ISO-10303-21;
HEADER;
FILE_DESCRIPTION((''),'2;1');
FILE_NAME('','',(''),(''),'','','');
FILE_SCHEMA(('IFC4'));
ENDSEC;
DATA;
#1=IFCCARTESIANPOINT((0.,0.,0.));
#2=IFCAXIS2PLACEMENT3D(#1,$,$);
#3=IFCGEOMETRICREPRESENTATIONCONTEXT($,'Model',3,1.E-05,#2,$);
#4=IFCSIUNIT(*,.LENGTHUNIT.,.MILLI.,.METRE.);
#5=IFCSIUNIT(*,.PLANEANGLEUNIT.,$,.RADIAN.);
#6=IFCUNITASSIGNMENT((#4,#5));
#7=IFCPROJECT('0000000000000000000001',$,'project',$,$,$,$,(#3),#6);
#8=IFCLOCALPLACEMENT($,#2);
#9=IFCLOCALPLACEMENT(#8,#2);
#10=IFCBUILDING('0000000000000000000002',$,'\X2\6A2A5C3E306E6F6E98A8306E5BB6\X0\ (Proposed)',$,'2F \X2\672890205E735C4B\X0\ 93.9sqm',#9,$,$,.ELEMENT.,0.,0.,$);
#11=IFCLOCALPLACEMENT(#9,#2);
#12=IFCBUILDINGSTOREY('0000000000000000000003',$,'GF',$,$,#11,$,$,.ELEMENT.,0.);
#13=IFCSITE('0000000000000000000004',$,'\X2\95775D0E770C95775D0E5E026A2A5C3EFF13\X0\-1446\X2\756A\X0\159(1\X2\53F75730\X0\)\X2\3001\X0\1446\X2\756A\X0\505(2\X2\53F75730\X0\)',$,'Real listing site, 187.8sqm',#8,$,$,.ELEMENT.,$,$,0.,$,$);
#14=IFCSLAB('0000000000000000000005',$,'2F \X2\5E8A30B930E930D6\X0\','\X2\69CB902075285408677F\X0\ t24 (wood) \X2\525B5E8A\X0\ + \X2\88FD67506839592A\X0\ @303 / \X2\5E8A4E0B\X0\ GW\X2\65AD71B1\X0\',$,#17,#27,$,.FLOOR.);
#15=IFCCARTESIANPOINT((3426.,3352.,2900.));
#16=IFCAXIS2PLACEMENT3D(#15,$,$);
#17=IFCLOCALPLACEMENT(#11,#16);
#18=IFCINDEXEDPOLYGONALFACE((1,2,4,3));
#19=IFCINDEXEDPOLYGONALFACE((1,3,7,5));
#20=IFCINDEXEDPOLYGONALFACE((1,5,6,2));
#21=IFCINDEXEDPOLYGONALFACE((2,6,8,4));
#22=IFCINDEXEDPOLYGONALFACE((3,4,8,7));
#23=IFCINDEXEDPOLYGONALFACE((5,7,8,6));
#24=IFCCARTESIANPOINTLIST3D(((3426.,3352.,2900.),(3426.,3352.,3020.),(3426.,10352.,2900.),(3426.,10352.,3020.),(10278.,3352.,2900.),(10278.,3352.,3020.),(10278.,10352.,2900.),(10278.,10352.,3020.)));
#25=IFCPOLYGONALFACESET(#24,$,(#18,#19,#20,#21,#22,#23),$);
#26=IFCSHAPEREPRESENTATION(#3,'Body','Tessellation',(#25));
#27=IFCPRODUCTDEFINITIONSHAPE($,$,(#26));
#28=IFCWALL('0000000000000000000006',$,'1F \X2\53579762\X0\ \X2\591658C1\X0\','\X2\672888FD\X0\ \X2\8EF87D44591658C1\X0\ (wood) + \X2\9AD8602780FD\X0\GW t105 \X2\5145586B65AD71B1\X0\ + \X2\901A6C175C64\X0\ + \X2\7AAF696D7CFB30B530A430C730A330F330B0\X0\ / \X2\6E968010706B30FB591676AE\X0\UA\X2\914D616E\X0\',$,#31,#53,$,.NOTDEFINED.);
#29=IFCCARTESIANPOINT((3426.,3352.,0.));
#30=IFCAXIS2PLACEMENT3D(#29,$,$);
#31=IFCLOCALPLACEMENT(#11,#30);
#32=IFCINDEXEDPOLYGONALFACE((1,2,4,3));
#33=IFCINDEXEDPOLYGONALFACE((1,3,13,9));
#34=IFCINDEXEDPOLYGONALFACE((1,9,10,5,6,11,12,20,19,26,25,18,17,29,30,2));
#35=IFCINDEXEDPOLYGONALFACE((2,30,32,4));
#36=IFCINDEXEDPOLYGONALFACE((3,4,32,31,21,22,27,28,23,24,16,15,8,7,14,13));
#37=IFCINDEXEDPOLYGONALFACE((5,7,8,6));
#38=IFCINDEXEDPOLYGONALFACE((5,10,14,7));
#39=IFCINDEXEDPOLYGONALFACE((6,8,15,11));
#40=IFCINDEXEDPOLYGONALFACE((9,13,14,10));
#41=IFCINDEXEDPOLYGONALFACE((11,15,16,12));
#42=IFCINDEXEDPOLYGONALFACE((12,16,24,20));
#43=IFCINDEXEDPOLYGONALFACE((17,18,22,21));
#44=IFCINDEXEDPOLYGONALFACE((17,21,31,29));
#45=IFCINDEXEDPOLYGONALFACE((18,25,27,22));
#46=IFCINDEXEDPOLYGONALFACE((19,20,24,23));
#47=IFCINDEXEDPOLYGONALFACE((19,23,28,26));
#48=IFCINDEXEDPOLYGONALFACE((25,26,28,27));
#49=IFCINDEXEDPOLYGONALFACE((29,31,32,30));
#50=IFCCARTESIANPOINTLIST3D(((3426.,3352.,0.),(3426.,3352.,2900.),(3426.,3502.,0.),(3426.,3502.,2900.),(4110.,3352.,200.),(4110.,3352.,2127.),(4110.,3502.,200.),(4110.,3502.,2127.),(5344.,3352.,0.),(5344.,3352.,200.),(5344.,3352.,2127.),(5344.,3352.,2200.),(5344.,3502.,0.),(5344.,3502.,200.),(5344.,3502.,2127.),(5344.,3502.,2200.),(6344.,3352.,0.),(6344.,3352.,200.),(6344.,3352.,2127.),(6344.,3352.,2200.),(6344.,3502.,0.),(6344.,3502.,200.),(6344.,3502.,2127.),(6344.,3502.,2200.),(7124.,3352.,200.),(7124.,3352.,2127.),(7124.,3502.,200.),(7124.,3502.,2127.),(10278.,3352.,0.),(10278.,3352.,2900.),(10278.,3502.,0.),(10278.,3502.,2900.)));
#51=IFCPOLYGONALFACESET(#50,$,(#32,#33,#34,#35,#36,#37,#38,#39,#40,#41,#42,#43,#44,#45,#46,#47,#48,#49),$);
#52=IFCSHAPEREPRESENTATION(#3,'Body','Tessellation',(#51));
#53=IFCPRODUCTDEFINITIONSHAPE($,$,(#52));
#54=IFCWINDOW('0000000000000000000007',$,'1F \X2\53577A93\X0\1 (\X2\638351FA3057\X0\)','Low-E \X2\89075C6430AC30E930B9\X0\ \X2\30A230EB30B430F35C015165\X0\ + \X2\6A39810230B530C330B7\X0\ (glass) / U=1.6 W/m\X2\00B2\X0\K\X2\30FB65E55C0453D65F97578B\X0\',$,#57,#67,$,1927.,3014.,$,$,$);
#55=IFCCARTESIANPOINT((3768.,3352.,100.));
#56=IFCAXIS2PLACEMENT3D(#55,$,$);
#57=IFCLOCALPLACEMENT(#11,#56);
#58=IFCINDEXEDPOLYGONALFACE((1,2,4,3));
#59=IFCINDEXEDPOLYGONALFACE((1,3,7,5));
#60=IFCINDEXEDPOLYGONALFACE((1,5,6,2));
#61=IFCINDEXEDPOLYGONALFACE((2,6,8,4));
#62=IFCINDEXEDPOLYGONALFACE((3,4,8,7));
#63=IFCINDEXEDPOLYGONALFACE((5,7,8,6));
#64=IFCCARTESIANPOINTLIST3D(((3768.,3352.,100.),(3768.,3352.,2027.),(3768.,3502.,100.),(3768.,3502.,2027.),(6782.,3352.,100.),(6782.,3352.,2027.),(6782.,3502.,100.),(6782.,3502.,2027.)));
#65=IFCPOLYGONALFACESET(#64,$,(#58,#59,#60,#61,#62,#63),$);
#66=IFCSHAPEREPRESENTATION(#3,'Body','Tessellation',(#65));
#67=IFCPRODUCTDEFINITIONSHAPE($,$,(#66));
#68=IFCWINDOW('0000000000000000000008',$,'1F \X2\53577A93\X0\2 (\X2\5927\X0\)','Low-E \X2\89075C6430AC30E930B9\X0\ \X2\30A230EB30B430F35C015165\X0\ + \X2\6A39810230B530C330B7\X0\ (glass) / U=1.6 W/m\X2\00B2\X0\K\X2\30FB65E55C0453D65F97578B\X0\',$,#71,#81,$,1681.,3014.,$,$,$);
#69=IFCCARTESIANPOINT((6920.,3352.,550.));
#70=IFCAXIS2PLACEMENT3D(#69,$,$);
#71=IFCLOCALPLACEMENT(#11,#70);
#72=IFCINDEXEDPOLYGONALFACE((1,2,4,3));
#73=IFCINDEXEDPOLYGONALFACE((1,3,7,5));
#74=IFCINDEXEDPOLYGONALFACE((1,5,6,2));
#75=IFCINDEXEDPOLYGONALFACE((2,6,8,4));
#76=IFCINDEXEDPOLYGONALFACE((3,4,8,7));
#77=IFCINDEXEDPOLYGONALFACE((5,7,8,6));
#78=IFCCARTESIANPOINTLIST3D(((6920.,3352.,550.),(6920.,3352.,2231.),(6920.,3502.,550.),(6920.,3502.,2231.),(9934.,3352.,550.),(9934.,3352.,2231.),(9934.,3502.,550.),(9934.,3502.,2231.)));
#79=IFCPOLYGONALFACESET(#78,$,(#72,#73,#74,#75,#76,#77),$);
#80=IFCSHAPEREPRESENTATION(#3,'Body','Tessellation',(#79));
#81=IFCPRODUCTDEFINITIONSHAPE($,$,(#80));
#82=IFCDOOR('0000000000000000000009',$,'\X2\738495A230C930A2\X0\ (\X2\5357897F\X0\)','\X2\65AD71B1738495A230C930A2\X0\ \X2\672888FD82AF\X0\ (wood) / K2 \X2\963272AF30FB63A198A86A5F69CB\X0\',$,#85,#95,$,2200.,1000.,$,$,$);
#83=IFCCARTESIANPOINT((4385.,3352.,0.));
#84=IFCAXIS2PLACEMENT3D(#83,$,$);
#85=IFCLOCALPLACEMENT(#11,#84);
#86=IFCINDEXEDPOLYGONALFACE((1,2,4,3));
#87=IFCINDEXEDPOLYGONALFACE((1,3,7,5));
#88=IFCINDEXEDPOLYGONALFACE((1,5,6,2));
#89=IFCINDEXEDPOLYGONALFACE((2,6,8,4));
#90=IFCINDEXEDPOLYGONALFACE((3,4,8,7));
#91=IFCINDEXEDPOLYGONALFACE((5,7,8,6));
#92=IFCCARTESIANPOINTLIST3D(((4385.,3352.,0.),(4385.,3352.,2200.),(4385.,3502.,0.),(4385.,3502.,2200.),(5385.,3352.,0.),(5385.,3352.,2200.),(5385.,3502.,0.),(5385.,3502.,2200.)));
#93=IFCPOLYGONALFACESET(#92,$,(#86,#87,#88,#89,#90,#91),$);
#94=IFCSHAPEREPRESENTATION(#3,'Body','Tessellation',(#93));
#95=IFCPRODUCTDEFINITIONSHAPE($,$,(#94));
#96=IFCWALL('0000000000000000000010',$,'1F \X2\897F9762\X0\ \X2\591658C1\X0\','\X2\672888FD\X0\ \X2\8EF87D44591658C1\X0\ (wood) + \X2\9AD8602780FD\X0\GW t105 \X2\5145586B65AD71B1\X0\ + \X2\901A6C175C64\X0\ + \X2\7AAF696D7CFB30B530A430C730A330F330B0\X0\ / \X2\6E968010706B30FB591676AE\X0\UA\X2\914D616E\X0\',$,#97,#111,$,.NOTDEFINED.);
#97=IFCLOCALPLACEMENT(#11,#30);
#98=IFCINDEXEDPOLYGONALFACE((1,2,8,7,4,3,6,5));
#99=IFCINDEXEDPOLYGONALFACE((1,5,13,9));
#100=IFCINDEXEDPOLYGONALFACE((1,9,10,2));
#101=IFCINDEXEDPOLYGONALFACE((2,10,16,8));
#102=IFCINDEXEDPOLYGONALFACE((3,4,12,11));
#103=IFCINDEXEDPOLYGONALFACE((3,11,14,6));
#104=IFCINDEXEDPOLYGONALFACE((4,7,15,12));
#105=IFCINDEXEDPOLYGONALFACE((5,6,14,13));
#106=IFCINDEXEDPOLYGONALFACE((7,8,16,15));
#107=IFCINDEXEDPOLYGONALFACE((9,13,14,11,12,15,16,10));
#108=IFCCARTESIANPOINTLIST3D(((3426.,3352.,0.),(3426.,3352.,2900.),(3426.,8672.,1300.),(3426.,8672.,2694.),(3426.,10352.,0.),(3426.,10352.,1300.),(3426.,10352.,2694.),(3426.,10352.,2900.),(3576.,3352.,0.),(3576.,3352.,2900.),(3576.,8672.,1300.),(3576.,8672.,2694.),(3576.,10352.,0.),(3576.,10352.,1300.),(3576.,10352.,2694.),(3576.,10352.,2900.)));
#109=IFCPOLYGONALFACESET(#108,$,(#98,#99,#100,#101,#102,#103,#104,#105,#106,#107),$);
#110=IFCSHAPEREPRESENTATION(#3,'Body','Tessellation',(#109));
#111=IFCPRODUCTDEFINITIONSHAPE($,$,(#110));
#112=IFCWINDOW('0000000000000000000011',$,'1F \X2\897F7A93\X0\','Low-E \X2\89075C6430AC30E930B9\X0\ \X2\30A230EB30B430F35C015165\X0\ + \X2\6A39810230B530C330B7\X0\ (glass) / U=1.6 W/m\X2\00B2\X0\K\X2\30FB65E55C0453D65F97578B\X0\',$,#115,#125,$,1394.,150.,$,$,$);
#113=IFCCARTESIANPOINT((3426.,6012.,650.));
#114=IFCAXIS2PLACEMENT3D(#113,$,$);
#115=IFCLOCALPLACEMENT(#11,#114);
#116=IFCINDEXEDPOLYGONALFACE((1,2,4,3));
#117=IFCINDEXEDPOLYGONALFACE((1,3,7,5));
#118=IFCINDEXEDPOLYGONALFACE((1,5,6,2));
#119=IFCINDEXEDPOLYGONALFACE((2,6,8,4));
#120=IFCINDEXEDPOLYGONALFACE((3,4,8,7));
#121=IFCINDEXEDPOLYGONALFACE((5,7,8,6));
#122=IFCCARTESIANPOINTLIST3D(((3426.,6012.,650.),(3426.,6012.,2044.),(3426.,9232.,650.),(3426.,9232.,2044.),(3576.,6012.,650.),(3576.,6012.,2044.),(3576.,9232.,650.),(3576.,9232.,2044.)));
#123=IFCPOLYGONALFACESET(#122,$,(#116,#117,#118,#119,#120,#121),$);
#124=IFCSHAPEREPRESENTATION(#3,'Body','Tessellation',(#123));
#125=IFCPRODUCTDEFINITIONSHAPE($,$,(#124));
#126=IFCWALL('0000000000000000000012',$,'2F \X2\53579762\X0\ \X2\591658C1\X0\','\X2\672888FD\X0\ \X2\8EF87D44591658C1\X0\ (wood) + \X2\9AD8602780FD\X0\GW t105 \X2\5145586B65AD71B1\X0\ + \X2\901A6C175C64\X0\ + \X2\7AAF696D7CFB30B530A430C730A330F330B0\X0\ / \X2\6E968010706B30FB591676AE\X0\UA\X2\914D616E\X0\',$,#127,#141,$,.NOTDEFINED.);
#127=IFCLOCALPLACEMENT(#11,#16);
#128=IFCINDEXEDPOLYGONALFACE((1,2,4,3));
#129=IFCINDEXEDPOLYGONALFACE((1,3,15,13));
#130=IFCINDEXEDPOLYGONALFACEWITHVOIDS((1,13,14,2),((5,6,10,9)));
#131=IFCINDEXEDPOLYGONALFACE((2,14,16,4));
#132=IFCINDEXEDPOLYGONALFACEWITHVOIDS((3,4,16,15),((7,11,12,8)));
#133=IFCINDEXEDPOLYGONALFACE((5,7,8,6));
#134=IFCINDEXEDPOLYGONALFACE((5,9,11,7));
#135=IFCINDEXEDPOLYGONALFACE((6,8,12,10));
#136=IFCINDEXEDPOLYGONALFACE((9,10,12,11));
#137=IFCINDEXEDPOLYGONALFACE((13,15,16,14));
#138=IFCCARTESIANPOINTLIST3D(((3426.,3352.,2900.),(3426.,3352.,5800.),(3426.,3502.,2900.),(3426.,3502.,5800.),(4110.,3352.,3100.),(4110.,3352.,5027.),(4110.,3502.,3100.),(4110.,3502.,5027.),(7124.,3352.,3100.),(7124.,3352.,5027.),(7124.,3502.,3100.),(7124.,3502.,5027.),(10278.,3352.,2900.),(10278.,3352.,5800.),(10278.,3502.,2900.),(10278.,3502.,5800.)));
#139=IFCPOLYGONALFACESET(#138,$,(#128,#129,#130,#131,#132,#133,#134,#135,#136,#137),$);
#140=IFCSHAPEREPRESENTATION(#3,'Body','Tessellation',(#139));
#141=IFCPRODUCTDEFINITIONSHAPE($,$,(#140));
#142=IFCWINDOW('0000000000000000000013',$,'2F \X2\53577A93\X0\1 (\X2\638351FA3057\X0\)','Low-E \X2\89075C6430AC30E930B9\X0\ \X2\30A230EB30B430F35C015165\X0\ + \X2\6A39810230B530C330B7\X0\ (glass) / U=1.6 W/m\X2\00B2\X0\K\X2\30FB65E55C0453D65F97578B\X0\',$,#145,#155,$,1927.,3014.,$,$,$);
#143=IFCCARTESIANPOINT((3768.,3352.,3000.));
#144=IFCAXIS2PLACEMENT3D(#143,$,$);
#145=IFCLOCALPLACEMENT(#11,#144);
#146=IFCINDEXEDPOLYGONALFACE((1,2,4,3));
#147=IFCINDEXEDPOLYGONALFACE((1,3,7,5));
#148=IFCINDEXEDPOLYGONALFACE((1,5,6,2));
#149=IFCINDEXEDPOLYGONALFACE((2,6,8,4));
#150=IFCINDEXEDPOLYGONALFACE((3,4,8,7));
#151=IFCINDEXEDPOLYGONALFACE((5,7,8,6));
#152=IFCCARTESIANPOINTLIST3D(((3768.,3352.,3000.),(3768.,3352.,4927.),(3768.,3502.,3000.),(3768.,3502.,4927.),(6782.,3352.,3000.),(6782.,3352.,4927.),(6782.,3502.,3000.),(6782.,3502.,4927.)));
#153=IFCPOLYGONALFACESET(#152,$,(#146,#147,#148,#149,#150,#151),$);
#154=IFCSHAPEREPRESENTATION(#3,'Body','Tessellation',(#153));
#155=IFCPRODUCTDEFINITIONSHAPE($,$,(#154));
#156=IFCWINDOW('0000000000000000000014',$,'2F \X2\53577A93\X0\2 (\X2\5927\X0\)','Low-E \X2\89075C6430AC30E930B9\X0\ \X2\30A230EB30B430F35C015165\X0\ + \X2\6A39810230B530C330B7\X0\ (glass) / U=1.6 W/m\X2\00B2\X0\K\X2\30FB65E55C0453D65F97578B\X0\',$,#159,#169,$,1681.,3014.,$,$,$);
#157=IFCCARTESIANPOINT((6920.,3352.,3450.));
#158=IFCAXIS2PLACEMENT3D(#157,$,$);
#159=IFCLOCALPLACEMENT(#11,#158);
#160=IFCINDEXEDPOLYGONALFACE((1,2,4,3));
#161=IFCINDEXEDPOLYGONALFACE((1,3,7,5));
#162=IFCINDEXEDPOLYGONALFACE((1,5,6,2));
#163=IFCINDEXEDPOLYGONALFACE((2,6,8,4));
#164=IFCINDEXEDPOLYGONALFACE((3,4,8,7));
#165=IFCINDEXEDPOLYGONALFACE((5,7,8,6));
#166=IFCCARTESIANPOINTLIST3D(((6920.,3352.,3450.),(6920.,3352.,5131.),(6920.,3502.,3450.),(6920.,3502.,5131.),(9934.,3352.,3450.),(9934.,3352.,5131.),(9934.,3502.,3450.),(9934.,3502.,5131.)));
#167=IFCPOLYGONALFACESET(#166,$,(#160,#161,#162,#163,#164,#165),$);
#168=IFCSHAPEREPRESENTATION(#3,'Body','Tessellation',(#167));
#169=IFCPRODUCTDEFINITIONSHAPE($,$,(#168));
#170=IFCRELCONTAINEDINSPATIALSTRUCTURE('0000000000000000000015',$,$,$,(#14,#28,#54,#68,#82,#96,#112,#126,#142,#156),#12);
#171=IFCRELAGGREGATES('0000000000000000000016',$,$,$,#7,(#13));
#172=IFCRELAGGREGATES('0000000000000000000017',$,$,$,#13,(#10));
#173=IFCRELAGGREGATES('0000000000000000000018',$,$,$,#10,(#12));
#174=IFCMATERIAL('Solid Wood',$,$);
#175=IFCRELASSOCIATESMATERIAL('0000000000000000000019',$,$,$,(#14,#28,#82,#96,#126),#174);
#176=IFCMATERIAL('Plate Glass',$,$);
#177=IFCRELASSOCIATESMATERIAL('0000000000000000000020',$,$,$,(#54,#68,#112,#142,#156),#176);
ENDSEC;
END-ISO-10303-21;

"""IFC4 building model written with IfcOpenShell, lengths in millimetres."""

from ifc_helpers import new_model, si_unit, frame, frame_2d, origin, place, context, project, spatial, rectangle, extrude, material, element, fill, save


model = new_model("IFC4")

# Units and contexts
model_context = context("Model", 3, precision=1e-05, world=origin())
ifc_project = project(units=[si_unit("LENGTHUNIT", "METRE", prefix="MILLI"), si_unit("PLANEANGLEUNIT", "RADIAN")], contexts=[model_context])

# Site, building, storey
site_placement = place(None, origin())
site = spatial("IfcSite", under=ifc_project, at=site_placement, Name="長崎県長崎市横尾３-1446番159(1号地)、1446番505(2号地)", ObjectType="Real listing site, 187.8sqm", CompositionType="ELEMENT", RefElevation=0.0)
building_placement = place(site_placement, origin())
building = spatial("IfcBuilding", under=site, at=building_placement, Name="横尾の潮風の家 (Proposed)", ObjectType="2F 木造平屋 93.9sqm", CompositionType="ELEMENT", ElevationOfRefHeight=0.0, ElevationOfTerrain=0.0)
storey_placement = place(building_placement, origin())
storey = spatial("IfcBuildingStorey", under=building, at=storey_placement, Name="GF", CompositionType="ELEMENT", Elevation=0.0)

# Slab
ifc_material_1 = material(Name="Solid Wood")
slab_1_placement = place(storey_placement, frame((3426.0, 3352.0, 2900.0)))
element("IfcSlab", 1, at=slab_1_placement, inside=storey, material=ifc_material_1, Name="2F 床スラブ", Description="構造用合板 t24 (wood) 剛床 + 製材根太 @303 / 床下 GW断熱", PredefinedType="FLOOR", context=model_context, shape_type="SweptSolid", body=[
    extrude(rectangle(XDim=6852.0, YDim=7000.0, at=frame_2d((3426.0, 3500.0))), frame((3426.0, 3352.0, 2900.0)), (0.0, 0.0, 1.0), 120.0),
])

# Wall, openings, windows, door
wall_1_placement = place(storey_placement, frame((3426.0, 3352.0, 0.0)))
wall_1 = element("IfcWall", 2, at=wall_1_placement, inside=storey, material=ifc_material_1, Name="1F 南面 外壁", Description="木製 軸組外壁 (wood) + 高性能GW t105 充填断熱 + 通気層 + 窯業系サイディング / 準耐火・外皮UA配慮", PredefinedType="NOTDEFINED", context=model_context, shape_type="SweptSolid", body=[
    extrude(rectangle(XDim=6852.0, YDim=150.0, at=frame_2d((3426.0, 75.0))), frame((3426.0, 3352.0, 0.0)), (0.0, 0.0, 1.0), 2900.0),
])
opening_1_placement = place(storey_placement, frame((3768.0, 3352.0, 100.0)))
opening_1 = element("IfcOpeningElement", 3, at=opening_1_placement, cuts=wall_1, PredefinedType="NOTDEFINED", context=model_context, shape_type="SweptSolid", body=[
    extrude(rectangle(XDim=3014.0, YDim=150.0, at=frame_2d((1507.0, 75.0))), frame((3768.0, 3352.0, 100.0)), (0.0, 0.0, 1.0), 1927.0),
])
opening_2_placement = place(storey_placement, frame((6920.0, 3352.0, 550.0)))
opening_2 = element("IfcOpeningElement", 4, at=opening_2_placement, cuts=wall_1, PredefinedType="NOTDEFINED", context=model_context, shape_type="SweptSolid", body=[
    extrude(rectangle(XDim=3014.0, YDim=150.0, at=frame_2d((1507.0, 75.0))), frame((6920.0, 3352.0, 550.0)), (0.0, 0.0, 1.0), 1681.0),
])
opening_3_placement = place(storey_placement, frame((4385.0, 3352.0, 0.0)))
opening_3 = element("IfcOpeningElement", 5, at=opening_3_placement, cuts=wall_1, PredefinedType="NOTDEFINED", context=model_context, shape_type="SweptSolid", body=[
    extrude(rectangle(XDim=1000.0, YDim=150.0, at=frame_2d((500.0, 75.0))), frame((4385.0, 3352.0, 0.0)), (0.0, 0.0, 1.0), 2200.0),
])
ifc_material_2 = material(Name="Plate Glass")
window_1_placement = place(storey_placement, frame((3768.0, 3352.0, 100.0)))
window_1 = element("IfcWindow", 6, at=window_1_placement, inside=storey, material=ifc_material_2, Name="1F 南窓1 (掃出し)", Description="Low-E 複層ガラス アルゴン封入 + 樹脂サッシ (glass) / U=1.6 W/m²K・日射取得型", OverallHeight=1927.0, OverallWidth=3014.0, context=model_context, shape_type="SweptSolid", body=[
    extrude(rectangle(XDim=3014.0, YDim=150.0, at=frame_2d((1507.0, 75.0))), frame((3768.0, 3352.0, 100.0)), (0.0, 0.0, 1.0), 1927.0),
])
fill(opening_1, window_1)
window_2_placement = place(storey_placement, frame((6920.0, 3352.0, 550.0)))
window_2 = element("IfcWindow", 7, at=window_2_placement, inside=storey, material=ifc_material_2, Name="1F 南窓2 (大)", Description="Low-E 複層ガラス アルゴン封入 + 樹脂サッシ (glass) / U=1.6 W/m²K・日射取得型", OverallHeight=1681.0, OverallWidth=3014.0, context=model_context, shape_type="SweptSolid", body=[
    extrude(rectangle(XDim=3014.0, YDim=150.0, at=frame_2d((1507.0, 75.0))), frame((6920.0, 3352.0, 550.0)), (0.0, 0.0, 1.0), 1681.0),
])
fill(opening_2, window_2)
door_placement = place(storey_placement, frame((4385.0, 3352.0, 0.0)))
door = element("IfcDoor", 8, at=door_placement, inside=storey, material=ifc_material_1, Name="玄関ドア (南西)", Description="断熱玄関ドア 木製芯 (wood) / K2 防犯・採風機構", OverallHeight=2200.0, OverallWidth=1000.0, context=model_context, shape_type="SweptSolid", body=[
    extrude(rectangle(XDim=1000.0, YDim=150.0, at=frame_2d((500.0, 75.0))), frame((4385.0, 3352.0, 0.0)), (0.0, 0.0, 1.0), 2200.0),
])
fill(opening_3, door)

# Wall, opening, window
wall_2_placement = place(storey_placement, frame((3426.0, 3352.0, 0.0)))
wall_2 = element("IfcWall", 9, at=wall_2_placement, inside=storey, material=ifc_material_1, Name="1F 西面 外壁", Description="木製 軸組外壁 (wood) + 高性能GW t105 充填断熱 + 通気層 + 窯業系サイディング / 準耐火・外皮UA配慮", PredefinedType="NOTDEFINED", context=model_context, shape_type="SweptSolid", body=[
    extrude(rectangle(XDim=150.0, YDim=7000.0, at=frame_2d((75.0, 3500.0))), frame((3426.0, 3352.0, 0.0)), (0.0, 0.0, 1.0), 2900.0),
])
opening_4_placement = place(storey_placement, frame((3426.0, 6012.0, 650.0)))
opening_4 = element("IfcOpeningElement", 10, at=opening_4_placement, cuts=wall_2, PredefinedType="NOTDEFINED", context=model_context, shape_type="SweptSolid", body=[
    extrude(rectangle(XDim=150.0, YDim=3220.0, at=frame_2d((75.0, 1610.0))), frame((3426.0, 6012.0, 650.0)), (0.0, 0.0, 1.0), 1394.0),
])
window_3_placement = place(storey_placement, frame((3426.0, 6012.0, 650.0)))
window_3 = element("IfcWindow", 11, at=window_3_placement, inside=storey, material=ifc_material_2, Name="1F 西窓", Description="Low-E 複層ガラス アルゴン封入 + 樹脂サッシ (glass) / U=1.6 W/m²K・日射取得型", OverallHeight=1394.0, OverallWidth=150.0, context=model_context, shape_type="SweptSolid", body=[
    extrude(rectangle(XDim=150.0, YDim=3220.0, at=frame_2d((75.0, 1610.0))), frame((3426.0, 6012.0, 650.0)), (0.0, 0.0, 1.0), 1394.0),
])
fill(opening_4, window_3)

# Wall, openings, windows
wall_3_placement = place(storey_placement, frame((3426.0, 3352.0, 2900.0)))
wall_3 = element("IfcWall", 12, at=wall_3_placement, inside=storey, material=ifc_material_1, Name="2F 南面 外壁", Description="木製 軸組外壁 (wood) + 高性能GW t105 充填断熱 + 通気層 + 窯業系サイディング / 準耐火・外皮UA配慮", PredefinedType="NOTDEFINED", context=model_context, shape_type="SweptSolid", body=[
    extrude(rectangle(XDim=6852.0, YDim=150.0, at=frame_2d((3426.0, 75.0))), frame((3426.0, 3352.0, 2900.0)), (0.0, 0.0, 1.0), 2900.0),
])
opening_5_placement = place(storey_placement, frame((3768.0, 3352.0, 3000.0)))
opening_5 = element("IfcOpeningElement", 13, at=opening_5_placement, cuts=wall_3, PredefinedType="NOTDEFINED", context=model_context, shape_type="SweptSolid", body=[
    extrude(rectangle(XDim=3014.0, YDim=150.0, at=frame_2d((1507.0, 75.0))), frame((3768.0, 3352.0, 3000.0)), (0.0, 0.0, 1.0), 1927.0),
])
opening_6_placement = place(storey_placement, frame((6920.0, 3352.0, 3450.0)))
opening_6 = element("IfcOpeningElement", 14, at=opening_6_placement, cuts=wall_3, PredefinedType="NOTDEFINED", context=model_context, shape_type="SweptSolid", body=[
    extrude(rectangle(XDim=3014.0, YDim=150.0, at=frame_2d((1507.0, 75.0))), frame((6920.0, 3352.0, 3450.0)), (0.0, 0.0, 1.0), 1681.0),
])
window_4_placement = place(storey_placement, frame((3768.0, 3352.0, 3000.0)))
window_4 = element("IfcWindow", 15, at=window_4_placement, inside=storey, material=ifc_material_2, Name="2F 南窓1 (掃出し)", Description="Low-E 複層ガラス アルゴン封入 + 樹脂サッシ (glass) / U=1.6 W/m²K・日射取得型", OverallHeight=1927.0, OverallWidth=3014.0, context=model_context, shape_type="SweptSolid", body=[
    extrude(rectangle(XDim=3014.0, YDim=150.0, at=frame_2d((1507.0, 75.0))), frame((3768.0, 3352.0, 3000.0)), (0.0, 0.0, 1.0), 1927.0),
])
fill(opening_5, window_4)
window_5_placement = place(storey_placement, frame((6920.0, 3352.0, 3450.0)))
window_5 = element("IfcWindow", 16, at=window_5_placement, inside=storey, material=ifc_material_2, Name="2F 南窓2 (大)", Description="Low-E 複層ガラス アルゴン封入 + 樹脂サッシ (glass) / U=1.6 W/m²K・日射取得型", OverallHeight=1681.0, OverallWidth=3014.0, context=model_context, shape_type="SweptSolid", body=[
    extrude(rectangle(XDim=3014.0, YDim=150.0, at=frame_2d((1507.0, 75.0))), frame((6920.0, 3352.0, 3450.0)), (0.0, 0.0, 1.0), 1681.0),
])
fill(opening_6, window_5)

save(model, "model.ifc")
